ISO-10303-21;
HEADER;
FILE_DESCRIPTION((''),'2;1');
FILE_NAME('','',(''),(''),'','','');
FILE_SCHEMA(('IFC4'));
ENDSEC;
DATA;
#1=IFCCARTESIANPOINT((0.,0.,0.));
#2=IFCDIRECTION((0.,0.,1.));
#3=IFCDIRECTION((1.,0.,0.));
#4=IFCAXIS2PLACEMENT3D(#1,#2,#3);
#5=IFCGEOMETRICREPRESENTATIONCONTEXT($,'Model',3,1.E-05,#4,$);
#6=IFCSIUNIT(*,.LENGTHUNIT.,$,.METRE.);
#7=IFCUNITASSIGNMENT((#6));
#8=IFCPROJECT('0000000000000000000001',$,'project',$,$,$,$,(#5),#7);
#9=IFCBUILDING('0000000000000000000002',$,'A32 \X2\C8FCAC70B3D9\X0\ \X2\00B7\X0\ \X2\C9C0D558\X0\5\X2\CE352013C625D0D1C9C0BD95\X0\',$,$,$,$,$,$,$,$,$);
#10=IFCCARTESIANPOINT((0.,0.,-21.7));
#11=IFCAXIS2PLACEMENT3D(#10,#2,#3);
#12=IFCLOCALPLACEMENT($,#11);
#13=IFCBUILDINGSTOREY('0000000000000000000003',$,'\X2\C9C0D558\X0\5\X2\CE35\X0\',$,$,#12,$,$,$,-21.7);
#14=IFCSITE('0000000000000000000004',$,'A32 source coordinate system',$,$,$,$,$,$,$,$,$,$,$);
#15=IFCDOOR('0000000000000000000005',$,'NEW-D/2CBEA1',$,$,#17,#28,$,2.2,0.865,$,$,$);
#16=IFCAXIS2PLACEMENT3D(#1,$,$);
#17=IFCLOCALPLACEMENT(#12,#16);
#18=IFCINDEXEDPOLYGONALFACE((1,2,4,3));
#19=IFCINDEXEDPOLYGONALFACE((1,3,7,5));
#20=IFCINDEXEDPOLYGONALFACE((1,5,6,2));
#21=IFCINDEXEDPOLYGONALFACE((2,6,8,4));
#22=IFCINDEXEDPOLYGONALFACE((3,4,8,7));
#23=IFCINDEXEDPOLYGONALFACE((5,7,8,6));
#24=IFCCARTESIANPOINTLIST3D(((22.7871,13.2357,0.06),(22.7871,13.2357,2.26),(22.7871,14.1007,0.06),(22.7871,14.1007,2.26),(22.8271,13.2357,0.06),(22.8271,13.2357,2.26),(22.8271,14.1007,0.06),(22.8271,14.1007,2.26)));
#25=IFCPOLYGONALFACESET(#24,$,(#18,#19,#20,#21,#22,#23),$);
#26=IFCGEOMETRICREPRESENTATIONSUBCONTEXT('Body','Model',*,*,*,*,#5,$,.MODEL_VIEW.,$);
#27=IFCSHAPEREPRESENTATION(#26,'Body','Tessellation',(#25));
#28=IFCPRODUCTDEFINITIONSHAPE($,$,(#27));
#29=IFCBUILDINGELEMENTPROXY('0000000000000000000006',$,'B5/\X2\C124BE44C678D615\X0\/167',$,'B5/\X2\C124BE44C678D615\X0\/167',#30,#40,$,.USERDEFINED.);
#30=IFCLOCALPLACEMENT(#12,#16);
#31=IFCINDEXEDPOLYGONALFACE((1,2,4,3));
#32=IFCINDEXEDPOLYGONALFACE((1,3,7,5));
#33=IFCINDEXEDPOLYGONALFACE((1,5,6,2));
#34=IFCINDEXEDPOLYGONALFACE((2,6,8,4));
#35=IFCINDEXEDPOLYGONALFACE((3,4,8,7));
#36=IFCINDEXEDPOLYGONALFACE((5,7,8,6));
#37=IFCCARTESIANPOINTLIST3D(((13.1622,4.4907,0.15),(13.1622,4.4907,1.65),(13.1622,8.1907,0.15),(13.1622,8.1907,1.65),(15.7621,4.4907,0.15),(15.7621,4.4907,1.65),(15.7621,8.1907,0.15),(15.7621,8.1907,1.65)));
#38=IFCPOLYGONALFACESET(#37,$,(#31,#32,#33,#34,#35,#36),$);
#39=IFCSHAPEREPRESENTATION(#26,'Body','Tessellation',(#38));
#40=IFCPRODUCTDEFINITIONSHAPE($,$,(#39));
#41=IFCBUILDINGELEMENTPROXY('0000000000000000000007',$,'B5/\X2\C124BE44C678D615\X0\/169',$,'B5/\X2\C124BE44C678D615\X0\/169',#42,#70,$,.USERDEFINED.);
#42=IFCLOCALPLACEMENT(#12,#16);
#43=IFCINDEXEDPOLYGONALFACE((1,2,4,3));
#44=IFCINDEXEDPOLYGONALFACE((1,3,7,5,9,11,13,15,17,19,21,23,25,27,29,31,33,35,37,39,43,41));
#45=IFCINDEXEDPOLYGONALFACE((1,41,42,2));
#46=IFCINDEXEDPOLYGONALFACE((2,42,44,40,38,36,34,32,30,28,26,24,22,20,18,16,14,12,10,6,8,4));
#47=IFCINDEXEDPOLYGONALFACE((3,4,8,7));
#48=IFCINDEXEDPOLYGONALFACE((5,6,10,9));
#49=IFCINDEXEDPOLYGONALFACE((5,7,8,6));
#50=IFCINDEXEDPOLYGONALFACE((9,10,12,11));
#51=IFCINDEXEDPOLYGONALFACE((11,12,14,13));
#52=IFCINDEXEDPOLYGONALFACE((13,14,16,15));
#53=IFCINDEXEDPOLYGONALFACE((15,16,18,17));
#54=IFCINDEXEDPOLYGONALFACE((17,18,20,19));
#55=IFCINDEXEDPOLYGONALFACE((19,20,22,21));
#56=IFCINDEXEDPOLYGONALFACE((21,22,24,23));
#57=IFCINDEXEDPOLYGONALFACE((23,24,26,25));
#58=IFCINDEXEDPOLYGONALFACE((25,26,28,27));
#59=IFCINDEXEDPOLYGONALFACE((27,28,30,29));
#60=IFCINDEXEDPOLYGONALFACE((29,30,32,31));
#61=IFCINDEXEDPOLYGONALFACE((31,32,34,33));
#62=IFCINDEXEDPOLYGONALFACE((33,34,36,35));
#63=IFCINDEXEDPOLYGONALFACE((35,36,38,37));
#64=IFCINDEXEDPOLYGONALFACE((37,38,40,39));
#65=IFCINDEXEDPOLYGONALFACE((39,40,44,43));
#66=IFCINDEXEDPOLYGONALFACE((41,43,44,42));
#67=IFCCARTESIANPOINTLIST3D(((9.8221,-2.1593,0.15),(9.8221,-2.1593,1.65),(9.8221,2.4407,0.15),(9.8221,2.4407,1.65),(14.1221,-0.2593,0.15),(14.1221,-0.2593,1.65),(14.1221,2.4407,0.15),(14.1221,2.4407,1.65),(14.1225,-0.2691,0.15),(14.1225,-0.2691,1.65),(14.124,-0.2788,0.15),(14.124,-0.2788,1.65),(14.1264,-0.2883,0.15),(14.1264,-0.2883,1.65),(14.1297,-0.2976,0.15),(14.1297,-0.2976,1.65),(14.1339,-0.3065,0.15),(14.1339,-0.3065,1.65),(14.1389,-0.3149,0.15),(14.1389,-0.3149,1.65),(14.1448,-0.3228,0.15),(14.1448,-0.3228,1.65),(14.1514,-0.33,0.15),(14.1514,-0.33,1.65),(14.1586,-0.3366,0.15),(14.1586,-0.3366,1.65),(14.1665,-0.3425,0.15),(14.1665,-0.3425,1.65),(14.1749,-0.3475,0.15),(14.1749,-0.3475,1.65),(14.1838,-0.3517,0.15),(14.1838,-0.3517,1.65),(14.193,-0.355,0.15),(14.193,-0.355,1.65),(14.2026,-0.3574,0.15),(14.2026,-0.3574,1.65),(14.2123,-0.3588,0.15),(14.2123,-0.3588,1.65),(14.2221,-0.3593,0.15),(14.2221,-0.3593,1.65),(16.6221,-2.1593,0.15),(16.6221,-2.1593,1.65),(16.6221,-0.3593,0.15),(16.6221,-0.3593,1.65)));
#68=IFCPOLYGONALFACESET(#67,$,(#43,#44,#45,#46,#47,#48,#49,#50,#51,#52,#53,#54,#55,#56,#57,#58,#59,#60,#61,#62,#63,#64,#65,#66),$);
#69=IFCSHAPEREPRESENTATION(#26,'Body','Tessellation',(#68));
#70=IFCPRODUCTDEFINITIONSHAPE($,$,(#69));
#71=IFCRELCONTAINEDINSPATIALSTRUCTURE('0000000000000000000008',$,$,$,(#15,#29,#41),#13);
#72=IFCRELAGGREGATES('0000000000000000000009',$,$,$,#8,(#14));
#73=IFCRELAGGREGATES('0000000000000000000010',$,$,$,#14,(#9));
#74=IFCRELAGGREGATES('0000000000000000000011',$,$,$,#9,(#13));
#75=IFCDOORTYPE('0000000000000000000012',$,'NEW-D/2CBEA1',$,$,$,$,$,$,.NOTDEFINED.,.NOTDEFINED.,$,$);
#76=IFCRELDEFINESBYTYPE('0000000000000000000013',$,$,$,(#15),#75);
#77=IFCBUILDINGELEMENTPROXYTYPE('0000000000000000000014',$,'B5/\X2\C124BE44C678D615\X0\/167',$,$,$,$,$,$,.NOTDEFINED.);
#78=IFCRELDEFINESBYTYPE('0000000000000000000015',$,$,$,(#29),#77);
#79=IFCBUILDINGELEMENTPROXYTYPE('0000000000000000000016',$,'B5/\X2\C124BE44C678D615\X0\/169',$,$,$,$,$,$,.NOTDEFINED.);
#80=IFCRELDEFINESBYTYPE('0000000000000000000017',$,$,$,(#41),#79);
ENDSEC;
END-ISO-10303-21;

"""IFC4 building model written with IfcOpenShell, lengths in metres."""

from ifc_helpers import new_model, si_unit, frame, origin, origin_with_axes, place, context, subcontext, project, spatial, polyline, outline, extrude, source, transform, mapped, type_object, type_shapes, element, save


model = new_model("IFC4")

# Units and contexts
model_context = context("Model", 3, precision=1e-05, world=origin_with_axes())
body_context = subcontext(model_context, "Body", "Model", "MODEL_VIEW")
ifc_project = project(units=[si_unit("LENGTHUNIT", "METRE")], contexts=[model_context])

# Site, building, storey
site = spatial("IfcSite", under=ifc_project, Name="A32 source coordinate system")
building = spatial("IfcBuilding", under=site, Name="A32 주거동 · 지하5층–옥탑지붕")
storey_placement = place(None, frame((0.0, 0.0, -21.7), z_axis=(0.0, 0.0, 1.0), x_axis=(1.0, 0.0, 0.0)))
storey = spatial("IfcBuildingStorey", under=building, at=storey_placement, Name="지하5층", Elevation=-21.7)

# Door
door_type_1 = type_object("IfcDoorType", Name="NEW-D/2CBEA1", OperationType="NOTDEFINED", PredefinedType="NOTDEFINED")
shared_shape_1 = source(origin(), body_context, "Body", "SweptSolid", [
    extrude(outline(polyline([(22.8271, 14.1007), (22.8271, 13.2357), (22.7871, 13.2357), (22.7871, 14.1007), (22.8271, 14.1007)])), frame((0.0, 0.0, 0.06)), (0.0, 0.0, 1.0), 2.2),
])
type_shapes(door_type_1, [shared_shape_1])
door_1_placement = place(storey_placement, origin_with_axes())
element("IfcDoor", 1, at=door_1_placement, inside=storey, type_object=door_type_1, Name="NEW-D/2CBEA1", OverallHeight=2.2, OverallWidth=0.865, context=body_context, shape_type="MappedRepresentation", body=[
    mapped(shared_shape_1, transform((0.0, 0.0, 0.0), scale=1.0)),
])

# Building element proxies
building_element_proxy_type_1 = type_object("IfcBuildingElementProxyType", Name="B5/설비외형/167", PredefinedType="NOTDEFINED")
shared_shape_2 = source(origin(), body_context, "Body", "SweptSolid", [
    extrude(outline(polyline([(15.7621, 8.1907), (15.7621, 4.4907), (13.1622, 4.4907), (13.1622, 8.1907), (15.7621, 8.1907)])), frame((0.0, 0.0, 0.15)), (0.0, 0.0, 1.0), 1.5),
])
type_shapes(building_element_proxy_type_1, [shared_shape_2])
proxy_1_placement = place(storey_placement, origin_with_axes())
element("IfcBuildingElementProxy", 2, at=proxy_1_placement, inside=storey, type_object=building_element_proxy_type_1, Name="B5/설비외형/167", ObjectType="B5/설비외형/167", PredefinedType="USERDEFINED", context=body_context, shape_type="MappedRepresentation", body=[
    mapped(shared_shape_2, transform((0.0, 0.0, 0.0), scale=1.0)),
])
building_element_proxy_type_2 = type_object("IfcBuildingElementProxyType", Name="B5/설비외형/169", PredefinedType="NOTDEFINED")
shared_shape_3 = source(origin(), body_context, "Body", "SweptSolid", [
    extrude(outline(polyline([(14.1221, 2.4407), (14.1221, -0.2593), (14.1225, -0.2691), (14.124, -0.2788), (14.1264, -0.2883), (14.1297, -0.2976), (14.1339, -0.3065), (14.1389, -0.3149), (14.1448, -0.3228), (14.1514, -0.33), (14.1586, -0.3366), (14.1665, -0.3425), (14.1749, -0.3475), (14.1838, -0.3517), (14.193, -0.355), (14.2026, -0.3574), (14.2123, -0.3588), (14.2221, -0.3593), (16.6221, -0.3593), (16.6221, -2.1593), (9.8221, -2.1593), (9.8221, 2.4407), (14.1221, 2.4407)])), frame((0.0, 0.0, 0.15)), (0.0, 0.0, 1.0), 1.5),
])
type_shapes(building_element_proxy_type_2, [shared_shape_3])
proxy_2_placement = place(storey_placement, origin_with_axes())
element("IfcBuildingElementProxy", 3, at=proxy_2_placement, inside=storey, type_object=building_element_proxy_type_2, Name="B5/설비외형/169", ObjectType="B5/설비외형/169", PredefinedType="USERDEFINED", context=body_context, shape_type="MappedRepresentation", body=[
    mapped(shared_shape_3, transform((0.0, 0.0, 0.0), scale=1.0)),
])

save(model, "model.ifc")
